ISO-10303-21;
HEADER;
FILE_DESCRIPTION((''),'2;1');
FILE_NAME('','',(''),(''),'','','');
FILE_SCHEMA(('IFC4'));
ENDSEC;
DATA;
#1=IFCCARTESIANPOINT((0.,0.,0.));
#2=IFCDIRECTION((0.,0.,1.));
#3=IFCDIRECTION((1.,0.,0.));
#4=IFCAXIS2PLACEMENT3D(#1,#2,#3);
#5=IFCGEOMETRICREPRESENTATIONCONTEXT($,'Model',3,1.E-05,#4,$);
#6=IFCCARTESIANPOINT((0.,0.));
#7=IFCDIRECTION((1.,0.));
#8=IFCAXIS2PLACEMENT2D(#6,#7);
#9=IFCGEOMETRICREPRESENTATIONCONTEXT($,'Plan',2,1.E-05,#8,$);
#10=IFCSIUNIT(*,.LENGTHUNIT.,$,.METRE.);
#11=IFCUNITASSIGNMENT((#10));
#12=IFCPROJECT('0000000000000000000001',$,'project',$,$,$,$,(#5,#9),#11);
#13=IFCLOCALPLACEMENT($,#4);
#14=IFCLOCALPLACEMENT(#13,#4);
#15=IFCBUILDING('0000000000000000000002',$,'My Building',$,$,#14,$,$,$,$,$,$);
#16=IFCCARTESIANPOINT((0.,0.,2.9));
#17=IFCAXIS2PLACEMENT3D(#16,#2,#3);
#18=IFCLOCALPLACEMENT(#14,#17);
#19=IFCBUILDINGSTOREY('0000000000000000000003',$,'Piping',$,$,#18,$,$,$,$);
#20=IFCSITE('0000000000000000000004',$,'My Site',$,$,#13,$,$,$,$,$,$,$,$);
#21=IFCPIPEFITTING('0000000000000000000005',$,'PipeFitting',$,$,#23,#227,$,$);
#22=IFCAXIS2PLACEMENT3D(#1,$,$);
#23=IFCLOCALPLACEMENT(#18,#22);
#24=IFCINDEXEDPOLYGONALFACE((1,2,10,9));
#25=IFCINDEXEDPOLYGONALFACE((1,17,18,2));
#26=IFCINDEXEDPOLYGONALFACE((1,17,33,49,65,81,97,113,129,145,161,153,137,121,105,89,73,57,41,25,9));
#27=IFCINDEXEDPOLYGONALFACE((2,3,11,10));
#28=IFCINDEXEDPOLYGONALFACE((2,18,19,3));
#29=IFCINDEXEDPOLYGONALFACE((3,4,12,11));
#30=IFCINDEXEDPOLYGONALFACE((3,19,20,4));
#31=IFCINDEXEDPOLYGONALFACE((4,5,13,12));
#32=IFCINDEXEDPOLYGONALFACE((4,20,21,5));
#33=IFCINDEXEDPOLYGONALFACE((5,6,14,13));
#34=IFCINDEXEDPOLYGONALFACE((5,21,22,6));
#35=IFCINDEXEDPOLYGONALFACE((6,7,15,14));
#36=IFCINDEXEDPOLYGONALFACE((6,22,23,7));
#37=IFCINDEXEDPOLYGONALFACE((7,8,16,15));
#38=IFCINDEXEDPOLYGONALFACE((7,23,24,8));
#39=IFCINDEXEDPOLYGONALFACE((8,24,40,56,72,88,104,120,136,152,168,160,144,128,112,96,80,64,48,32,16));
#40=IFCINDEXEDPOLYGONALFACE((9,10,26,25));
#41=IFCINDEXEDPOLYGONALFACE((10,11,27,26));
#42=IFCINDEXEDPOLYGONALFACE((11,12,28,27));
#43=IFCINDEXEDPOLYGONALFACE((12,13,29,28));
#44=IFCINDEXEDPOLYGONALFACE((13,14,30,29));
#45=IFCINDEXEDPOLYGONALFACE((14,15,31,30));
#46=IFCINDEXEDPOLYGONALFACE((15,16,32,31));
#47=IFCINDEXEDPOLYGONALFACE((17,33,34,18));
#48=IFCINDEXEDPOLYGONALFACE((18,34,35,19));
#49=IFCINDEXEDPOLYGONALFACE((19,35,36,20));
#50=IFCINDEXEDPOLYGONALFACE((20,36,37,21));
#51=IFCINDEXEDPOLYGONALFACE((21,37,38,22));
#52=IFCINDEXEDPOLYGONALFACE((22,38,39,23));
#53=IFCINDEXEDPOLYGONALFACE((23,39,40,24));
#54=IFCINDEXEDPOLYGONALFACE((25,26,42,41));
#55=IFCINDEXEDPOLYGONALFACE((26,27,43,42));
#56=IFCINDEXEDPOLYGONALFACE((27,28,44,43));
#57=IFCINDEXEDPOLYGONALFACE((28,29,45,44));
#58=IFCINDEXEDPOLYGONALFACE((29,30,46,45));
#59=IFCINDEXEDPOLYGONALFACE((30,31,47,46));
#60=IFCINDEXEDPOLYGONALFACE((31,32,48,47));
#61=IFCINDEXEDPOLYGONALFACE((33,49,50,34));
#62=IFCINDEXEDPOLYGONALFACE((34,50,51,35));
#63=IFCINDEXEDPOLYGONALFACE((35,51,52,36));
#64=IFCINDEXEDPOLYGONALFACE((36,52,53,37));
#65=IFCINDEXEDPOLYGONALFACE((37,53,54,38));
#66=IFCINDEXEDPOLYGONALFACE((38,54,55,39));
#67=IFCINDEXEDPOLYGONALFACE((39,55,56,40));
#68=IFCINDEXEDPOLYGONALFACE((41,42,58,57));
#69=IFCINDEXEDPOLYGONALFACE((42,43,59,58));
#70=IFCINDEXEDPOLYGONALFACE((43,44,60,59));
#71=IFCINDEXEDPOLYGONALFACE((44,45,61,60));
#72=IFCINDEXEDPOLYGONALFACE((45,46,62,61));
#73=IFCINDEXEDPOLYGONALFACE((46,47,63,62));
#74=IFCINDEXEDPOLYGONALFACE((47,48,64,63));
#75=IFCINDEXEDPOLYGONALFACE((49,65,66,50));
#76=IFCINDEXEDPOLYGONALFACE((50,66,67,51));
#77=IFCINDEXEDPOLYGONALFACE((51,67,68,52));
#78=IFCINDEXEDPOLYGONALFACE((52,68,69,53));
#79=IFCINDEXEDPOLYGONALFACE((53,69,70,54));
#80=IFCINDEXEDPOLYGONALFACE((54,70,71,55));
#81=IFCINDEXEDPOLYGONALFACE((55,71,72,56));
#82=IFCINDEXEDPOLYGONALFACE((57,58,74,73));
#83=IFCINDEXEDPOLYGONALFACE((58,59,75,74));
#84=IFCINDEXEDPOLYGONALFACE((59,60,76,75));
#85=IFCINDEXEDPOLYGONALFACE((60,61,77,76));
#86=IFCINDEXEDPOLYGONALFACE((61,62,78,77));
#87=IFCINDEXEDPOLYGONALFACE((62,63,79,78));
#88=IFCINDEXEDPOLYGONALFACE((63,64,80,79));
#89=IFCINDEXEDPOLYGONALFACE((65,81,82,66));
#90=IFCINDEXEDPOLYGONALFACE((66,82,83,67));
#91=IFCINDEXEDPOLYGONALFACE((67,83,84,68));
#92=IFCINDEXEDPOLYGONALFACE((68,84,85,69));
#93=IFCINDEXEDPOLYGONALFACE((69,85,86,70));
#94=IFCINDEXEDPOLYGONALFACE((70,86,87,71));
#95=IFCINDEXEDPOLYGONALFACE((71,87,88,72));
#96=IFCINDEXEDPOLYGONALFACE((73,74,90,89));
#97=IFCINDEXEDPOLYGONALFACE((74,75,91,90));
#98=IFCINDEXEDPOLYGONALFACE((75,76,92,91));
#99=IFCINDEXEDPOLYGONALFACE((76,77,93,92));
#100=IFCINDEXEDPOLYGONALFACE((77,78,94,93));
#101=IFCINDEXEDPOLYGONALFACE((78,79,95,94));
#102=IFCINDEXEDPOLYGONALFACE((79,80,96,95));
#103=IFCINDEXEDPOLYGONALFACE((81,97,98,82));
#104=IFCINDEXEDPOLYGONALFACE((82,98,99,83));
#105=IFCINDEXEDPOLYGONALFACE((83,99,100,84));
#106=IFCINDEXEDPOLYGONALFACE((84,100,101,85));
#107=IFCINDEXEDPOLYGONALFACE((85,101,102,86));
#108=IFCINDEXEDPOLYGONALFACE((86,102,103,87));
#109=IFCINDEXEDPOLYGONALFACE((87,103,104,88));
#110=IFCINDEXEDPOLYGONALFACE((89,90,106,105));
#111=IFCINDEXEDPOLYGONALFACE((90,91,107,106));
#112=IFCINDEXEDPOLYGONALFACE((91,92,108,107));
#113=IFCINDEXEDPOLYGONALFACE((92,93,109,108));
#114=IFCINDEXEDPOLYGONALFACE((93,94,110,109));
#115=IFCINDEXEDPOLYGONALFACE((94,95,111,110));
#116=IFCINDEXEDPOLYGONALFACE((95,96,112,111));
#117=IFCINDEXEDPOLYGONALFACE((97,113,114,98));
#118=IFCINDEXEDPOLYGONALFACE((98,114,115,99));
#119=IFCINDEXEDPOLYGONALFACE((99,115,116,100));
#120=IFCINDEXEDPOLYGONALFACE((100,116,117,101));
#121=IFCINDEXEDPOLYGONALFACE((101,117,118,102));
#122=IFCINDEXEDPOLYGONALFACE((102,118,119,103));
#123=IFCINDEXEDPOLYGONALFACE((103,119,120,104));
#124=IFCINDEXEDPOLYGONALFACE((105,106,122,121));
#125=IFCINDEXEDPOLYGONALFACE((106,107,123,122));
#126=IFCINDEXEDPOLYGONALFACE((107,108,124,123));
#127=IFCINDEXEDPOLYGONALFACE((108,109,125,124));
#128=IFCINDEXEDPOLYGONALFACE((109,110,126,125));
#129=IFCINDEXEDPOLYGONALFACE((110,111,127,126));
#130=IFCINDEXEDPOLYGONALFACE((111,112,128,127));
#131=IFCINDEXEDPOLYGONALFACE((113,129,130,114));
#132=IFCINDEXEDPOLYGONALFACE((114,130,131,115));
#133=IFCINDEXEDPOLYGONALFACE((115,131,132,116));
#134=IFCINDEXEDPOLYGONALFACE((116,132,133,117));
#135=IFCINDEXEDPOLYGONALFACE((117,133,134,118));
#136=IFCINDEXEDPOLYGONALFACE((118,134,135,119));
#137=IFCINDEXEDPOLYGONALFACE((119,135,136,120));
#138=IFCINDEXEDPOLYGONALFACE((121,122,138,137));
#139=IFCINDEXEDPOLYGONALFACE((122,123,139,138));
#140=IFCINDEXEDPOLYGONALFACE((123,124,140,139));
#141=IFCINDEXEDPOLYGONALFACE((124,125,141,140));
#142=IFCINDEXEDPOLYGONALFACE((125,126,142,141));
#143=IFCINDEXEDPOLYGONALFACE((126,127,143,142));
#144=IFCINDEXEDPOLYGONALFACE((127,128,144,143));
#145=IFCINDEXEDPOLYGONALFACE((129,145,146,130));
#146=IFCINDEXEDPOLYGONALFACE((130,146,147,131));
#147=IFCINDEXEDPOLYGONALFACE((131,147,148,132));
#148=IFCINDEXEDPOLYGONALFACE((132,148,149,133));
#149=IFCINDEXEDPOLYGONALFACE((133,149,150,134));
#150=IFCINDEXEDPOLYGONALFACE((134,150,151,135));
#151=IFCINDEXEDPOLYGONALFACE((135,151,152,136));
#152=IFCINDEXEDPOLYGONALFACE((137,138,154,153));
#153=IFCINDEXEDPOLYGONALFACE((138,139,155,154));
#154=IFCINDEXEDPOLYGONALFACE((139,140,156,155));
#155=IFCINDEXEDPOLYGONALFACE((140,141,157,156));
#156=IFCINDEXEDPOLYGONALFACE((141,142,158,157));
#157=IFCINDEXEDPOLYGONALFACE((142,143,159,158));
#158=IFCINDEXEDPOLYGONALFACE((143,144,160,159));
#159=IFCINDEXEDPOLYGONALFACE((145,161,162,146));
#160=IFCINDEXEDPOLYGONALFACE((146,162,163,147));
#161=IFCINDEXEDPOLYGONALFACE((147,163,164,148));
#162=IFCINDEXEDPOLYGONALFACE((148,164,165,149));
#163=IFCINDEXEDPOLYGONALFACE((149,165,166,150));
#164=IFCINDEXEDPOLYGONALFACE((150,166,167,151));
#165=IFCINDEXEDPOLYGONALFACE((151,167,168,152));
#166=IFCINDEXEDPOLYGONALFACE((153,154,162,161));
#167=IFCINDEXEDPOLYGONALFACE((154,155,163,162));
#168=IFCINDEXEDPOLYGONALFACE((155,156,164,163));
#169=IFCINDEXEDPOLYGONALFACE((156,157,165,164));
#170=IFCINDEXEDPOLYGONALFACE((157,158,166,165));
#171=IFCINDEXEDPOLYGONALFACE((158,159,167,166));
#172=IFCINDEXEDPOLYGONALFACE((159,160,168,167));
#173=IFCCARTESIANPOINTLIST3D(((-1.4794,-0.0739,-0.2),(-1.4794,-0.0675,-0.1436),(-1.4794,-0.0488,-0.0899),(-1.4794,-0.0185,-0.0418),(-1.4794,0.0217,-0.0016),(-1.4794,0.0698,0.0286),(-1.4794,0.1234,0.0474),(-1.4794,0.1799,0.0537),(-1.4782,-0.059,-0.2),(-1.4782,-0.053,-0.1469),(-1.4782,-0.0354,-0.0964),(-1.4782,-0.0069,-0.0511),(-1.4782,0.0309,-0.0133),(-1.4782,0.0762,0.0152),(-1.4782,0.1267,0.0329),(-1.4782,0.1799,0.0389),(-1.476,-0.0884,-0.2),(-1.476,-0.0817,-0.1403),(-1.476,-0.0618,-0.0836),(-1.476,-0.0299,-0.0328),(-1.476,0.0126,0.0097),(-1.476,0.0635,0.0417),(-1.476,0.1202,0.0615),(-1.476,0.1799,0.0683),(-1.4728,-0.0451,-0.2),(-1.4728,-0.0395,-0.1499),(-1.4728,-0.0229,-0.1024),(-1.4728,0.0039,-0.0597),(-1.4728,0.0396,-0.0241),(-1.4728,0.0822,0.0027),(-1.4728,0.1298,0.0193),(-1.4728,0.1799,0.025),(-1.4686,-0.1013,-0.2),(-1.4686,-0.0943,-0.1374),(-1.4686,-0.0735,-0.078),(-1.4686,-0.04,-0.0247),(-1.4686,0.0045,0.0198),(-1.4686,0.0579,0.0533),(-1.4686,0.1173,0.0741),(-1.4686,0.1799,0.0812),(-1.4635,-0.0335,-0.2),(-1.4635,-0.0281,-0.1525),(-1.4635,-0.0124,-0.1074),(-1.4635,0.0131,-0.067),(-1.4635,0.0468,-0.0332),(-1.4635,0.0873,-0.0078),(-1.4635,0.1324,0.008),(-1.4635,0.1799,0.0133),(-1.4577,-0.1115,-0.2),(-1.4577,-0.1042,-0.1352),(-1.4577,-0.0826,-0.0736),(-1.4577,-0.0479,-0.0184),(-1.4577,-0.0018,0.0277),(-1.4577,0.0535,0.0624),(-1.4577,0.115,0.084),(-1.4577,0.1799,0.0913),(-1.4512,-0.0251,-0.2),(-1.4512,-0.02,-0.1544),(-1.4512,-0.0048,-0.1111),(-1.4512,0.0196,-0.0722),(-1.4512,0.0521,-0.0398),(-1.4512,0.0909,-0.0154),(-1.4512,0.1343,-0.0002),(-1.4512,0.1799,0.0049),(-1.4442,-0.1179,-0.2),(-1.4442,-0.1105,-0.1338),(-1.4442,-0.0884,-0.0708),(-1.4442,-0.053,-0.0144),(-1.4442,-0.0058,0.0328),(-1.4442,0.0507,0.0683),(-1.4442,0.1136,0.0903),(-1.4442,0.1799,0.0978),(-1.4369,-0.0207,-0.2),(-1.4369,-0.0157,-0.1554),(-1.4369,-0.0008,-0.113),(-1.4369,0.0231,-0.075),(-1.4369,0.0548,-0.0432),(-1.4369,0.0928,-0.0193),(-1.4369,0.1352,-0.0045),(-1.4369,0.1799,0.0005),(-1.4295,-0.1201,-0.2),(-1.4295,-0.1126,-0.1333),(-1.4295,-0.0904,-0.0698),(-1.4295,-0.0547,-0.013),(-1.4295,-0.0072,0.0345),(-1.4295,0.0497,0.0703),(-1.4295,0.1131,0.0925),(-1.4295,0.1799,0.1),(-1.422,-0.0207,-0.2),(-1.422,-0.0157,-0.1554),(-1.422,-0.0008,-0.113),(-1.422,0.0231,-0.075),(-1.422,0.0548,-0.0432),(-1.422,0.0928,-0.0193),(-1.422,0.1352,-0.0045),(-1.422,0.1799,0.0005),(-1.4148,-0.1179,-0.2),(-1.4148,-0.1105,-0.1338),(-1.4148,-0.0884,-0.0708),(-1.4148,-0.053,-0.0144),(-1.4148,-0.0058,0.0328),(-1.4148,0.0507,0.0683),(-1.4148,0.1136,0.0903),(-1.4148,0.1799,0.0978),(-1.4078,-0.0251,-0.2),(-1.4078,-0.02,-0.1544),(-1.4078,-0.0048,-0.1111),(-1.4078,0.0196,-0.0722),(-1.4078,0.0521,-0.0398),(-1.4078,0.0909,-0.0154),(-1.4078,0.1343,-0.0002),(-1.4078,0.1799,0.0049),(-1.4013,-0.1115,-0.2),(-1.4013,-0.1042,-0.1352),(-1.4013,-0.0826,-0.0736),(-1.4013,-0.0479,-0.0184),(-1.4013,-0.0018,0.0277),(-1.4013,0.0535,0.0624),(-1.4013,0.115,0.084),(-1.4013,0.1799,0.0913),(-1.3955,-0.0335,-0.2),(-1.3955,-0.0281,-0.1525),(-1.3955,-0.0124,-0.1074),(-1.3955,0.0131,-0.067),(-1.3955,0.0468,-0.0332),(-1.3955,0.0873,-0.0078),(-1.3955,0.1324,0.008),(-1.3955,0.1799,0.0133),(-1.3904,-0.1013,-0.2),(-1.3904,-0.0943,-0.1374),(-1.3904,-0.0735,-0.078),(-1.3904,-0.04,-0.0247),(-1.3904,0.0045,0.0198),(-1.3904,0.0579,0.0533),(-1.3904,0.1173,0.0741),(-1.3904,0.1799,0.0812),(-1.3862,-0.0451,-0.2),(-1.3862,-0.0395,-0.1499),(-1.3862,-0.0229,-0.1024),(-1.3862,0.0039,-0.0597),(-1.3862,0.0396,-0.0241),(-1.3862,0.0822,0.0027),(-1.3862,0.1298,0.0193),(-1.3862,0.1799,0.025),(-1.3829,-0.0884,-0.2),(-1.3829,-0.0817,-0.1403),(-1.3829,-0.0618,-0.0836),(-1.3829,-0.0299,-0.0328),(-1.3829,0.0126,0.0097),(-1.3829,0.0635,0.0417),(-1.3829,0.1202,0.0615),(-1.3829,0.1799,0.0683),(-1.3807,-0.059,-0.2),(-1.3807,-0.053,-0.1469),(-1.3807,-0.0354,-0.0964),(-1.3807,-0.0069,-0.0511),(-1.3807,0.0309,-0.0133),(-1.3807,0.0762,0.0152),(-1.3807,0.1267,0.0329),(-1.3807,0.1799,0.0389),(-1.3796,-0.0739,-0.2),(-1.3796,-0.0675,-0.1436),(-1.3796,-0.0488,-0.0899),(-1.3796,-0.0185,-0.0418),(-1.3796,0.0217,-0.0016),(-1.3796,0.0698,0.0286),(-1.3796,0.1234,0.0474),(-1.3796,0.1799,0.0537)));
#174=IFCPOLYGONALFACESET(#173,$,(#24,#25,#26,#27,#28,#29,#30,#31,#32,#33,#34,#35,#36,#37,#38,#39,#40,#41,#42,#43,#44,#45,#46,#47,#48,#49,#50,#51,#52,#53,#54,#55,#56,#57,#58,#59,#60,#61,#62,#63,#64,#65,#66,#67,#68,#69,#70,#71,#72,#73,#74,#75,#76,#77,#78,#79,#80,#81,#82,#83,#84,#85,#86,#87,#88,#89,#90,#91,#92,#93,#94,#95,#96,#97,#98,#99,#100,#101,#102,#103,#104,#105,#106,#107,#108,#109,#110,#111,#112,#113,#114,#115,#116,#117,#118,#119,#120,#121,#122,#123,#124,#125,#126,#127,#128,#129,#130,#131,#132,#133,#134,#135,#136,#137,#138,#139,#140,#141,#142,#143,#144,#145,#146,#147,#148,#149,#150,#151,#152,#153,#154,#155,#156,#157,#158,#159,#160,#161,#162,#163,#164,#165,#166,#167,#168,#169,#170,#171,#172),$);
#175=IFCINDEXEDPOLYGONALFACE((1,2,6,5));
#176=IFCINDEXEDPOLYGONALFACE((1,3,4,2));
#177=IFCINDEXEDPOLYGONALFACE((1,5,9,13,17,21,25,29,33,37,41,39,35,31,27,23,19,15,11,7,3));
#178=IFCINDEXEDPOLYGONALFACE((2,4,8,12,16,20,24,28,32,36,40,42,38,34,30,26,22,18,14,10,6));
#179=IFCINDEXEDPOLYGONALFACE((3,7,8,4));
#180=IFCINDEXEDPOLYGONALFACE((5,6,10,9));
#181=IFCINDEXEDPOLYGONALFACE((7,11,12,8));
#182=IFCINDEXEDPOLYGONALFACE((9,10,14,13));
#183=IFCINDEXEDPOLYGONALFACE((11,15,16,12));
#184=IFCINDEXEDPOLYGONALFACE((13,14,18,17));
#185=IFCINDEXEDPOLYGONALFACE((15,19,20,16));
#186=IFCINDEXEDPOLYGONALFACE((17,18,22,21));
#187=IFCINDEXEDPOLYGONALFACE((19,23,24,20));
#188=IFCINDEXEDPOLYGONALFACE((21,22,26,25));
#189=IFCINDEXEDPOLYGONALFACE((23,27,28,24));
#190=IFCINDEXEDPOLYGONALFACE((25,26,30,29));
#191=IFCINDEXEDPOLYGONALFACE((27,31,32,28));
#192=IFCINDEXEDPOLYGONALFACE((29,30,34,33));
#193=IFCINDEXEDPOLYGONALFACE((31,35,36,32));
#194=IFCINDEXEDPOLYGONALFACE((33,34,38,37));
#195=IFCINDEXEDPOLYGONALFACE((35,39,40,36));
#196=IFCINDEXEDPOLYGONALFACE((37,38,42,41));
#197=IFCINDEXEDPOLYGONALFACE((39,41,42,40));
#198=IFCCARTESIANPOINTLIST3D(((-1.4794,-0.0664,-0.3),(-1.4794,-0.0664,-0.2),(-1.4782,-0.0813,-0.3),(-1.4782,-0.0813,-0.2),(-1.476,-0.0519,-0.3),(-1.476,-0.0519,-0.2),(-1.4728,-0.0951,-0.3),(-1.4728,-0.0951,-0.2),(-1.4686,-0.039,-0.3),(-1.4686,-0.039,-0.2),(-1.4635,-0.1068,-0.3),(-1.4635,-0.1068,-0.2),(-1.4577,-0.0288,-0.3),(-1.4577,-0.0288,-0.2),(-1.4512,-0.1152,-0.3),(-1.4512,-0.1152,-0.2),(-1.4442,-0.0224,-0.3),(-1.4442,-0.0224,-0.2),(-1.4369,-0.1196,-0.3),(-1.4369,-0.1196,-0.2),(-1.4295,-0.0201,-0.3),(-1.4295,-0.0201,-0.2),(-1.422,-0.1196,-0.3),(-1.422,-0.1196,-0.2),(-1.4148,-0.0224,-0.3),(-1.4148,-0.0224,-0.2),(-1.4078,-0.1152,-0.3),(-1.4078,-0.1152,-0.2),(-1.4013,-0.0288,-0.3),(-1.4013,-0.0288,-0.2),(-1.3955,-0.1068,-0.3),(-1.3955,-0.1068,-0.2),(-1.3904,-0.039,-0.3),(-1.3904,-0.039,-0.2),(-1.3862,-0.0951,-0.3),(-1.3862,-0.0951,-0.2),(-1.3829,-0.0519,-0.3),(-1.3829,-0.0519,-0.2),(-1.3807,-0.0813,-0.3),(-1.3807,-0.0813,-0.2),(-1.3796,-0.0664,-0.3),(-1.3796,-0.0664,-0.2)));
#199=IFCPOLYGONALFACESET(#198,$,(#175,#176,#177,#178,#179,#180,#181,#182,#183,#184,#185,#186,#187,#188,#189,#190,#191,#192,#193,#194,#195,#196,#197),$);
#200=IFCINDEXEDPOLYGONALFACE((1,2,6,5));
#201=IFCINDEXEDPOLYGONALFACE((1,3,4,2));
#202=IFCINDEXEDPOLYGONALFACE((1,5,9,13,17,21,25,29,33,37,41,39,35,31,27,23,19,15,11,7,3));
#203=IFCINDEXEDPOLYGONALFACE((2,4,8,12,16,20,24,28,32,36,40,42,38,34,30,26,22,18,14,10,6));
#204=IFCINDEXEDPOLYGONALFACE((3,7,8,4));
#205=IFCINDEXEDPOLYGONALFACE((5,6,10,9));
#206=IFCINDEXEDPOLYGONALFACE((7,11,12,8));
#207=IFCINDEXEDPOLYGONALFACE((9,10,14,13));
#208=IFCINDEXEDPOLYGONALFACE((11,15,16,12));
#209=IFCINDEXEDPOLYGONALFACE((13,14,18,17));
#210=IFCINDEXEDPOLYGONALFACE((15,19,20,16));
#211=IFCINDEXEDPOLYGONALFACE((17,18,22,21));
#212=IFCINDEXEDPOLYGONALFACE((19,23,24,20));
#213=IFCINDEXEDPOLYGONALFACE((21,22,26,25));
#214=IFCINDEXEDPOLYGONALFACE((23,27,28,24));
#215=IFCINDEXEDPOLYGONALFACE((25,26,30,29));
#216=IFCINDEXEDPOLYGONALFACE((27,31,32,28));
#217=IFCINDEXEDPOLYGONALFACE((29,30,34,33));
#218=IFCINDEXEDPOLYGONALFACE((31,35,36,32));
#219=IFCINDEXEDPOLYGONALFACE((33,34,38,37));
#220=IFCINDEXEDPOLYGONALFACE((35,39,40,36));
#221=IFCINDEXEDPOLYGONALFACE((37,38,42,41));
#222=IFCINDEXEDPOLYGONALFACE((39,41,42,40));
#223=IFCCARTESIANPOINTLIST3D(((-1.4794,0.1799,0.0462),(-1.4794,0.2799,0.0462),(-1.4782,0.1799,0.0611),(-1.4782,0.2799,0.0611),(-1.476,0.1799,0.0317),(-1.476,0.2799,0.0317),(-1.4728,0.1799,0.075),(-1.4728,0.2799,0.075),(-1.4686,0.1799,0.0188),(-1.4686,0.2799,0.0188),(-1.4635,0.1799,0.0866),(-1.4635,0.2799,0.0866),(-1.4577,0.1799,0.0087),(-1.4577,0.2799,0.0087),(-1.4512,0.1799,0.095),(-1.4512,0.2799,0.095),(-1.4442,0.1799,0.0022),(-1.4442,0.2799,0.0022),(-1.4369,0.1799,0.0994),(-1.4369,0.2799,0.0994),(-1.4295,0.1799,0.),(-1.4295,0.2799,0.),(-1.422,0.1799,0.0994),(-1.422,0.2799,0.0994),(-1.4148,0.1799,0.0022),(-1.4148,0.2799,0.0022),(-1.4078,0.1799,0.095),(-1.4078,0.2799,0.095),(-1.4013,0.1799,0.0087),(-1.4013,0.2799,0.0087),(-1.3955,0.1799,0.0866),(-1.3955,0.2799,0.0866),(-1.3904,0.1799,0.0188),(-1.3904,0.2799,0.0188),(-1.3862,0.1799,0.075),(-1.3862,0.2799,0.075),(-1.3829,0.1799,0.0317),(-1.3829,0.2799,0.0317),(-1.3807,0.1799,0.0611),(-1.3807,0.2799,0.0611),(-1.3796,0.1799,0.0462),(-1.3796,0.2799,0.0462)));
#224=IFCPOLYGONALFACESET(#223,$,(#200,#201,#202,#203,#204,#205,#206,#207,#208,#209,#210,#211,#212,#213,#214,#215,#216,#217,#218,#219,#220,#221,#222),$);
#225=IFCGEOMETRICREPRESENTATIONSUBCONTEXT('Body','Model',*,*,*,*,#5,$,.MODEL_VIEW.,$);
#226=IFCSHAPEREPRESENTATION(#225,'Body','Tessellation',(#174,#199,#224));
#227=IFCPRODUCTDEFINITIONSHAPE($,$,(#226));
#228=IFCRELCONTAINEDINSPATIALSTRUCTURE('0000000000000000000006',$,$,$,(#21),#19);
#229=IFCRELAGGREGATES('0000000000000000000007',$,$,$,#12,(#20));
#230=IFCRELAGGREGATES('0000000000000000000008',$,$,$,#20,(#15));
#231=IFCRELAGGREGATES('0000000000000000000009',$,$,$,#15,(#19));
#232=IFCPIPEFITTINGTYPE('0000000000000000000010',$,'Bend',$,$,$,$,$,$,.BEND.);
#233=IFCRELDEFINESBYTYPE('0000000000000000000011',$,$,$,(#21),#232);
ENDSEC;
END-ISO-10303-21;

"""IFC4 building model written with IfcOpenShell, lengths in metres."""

from ifc_helpers import new_model, entity, si_unit, frame, origin_with_axes, origin_2d_with_axis, place, context, subcontext, project, spatial, line, indexed_curve, circle, outline, extrude, source, transform, mapped, type_object, type_shapes, element, save


model = new_model("IFC4")

# Units and contexts
model_context = context("Model", 3, precision=1e-05, world=origin_with_axes())
plan_context = context("Plan", 2, precision=1e-05, world=origin_2d_with_axis())
body_context = subcontext(model_context, "Body", "Model", "MODEL_VIEW")
ifc_project = project(units=[si_unit("LENGTHUNIT", "METRE")], contexts=[model_context, plan_context])

# Site, building, storey
site_placement = place(None, origin_with_axes())
site = spatial("IfcSite", under=ifc_project, at=site_placement, Name="My Site")
building_placement = place(site_placement, origin_with_axes())
building = spatial("IfcBuilding", under=site, at=building_placement, Name="My Building")
storey_placement = place(building_placement, frame((0.0, 0.0, 2.9), z_axis=(0.0, 0.0, 1.0), x_axis=(1.0, 0.0, 0.0)))
storey = spatial("IfcBuildingStorey", under=building, at=storey_placement, Name="Piping")

# Shared definitions
pipe_fitting_type_1 = type_object("IfcPipeFittingType", Name="Bend", PredefinedType="BEND")
shared_shape = source(origin_with_axes(), body_context, "Body", "SolidModel", [
    entity("IfcSweptDiskSolid", entity("IfcIndexedPolyCurve", entity("IfcCartesianPointList3D", [[0.0, 0.0, -0.1], [0.0732, 0.0, -0.2768], [0.25, 0.0, -0.35]]), [entity("IfcArcIndex", [1, 2, 3])]), 0.05),
    extrude(circle(Radius=0.05), origin_with_axes(), (0.0, 0.0, -1.0), 0.1),
    extrude(circle(Radius=0.05), frame((0.25, 0.0, -0.35), z_axis=(1.0, 0.0, 0.0), x_axis=(0.0, 0.0, 1.0)), (0.0, 0.0, 1.0), 0.1),
])
type_shapes(pipe_fitting_type_1, [shared_shape])

# Pipe fitting, opening
pipe_fitting_1_placement = place(storey_placement, frame((-1.4295, -0.0701, -0.3), z_axis=(0.0, 0.0, -1.0), x_axis=(0.0, 1.0, 0.0)))
pipe_fitting_1 = element("IfcPipeFitting", 1, at=pipe_fitting_1_placement, inside=storey, type_object=pipe_fitting_type_1, Name="PipeFitting", context=body_context, shape_type="MappedRepresentation", body=[
    mapped(shared_shape, transform((0.0, 0.0, 0.0), x_axis=(1.0, 0.0, 0.0), y_axis=(0.0, 1.0, 0.0), z_axis=(0.0, 0.0, 1.0), scale=1.0)),
])
opening_1_placement = place(pipe_fitting_1_placement, frame((0.0701, 1.4295, 2.6), z_axis=(0.0, 0.0, -1.0), x_axis=(0.0, 1.0, 0.0)))
element("IfcOpeningElement", 2, at=opening_1_placement, cuts=pipe_fitting_1, PredefinedType="OPENING", context=body_context, shape_type="SweptSolid", body=[
    extrude(outline(indexed_curve([(0.0, 0.0), (0.5, 0.0), (0.5, 0.5), (0.0, 0.5)], segments=[line(1, 2, 3, 4, 1)])), origin_with_axes(), (0.0, 0.0, 1.0), 0.5),
])

save(model, "model.ifc")
